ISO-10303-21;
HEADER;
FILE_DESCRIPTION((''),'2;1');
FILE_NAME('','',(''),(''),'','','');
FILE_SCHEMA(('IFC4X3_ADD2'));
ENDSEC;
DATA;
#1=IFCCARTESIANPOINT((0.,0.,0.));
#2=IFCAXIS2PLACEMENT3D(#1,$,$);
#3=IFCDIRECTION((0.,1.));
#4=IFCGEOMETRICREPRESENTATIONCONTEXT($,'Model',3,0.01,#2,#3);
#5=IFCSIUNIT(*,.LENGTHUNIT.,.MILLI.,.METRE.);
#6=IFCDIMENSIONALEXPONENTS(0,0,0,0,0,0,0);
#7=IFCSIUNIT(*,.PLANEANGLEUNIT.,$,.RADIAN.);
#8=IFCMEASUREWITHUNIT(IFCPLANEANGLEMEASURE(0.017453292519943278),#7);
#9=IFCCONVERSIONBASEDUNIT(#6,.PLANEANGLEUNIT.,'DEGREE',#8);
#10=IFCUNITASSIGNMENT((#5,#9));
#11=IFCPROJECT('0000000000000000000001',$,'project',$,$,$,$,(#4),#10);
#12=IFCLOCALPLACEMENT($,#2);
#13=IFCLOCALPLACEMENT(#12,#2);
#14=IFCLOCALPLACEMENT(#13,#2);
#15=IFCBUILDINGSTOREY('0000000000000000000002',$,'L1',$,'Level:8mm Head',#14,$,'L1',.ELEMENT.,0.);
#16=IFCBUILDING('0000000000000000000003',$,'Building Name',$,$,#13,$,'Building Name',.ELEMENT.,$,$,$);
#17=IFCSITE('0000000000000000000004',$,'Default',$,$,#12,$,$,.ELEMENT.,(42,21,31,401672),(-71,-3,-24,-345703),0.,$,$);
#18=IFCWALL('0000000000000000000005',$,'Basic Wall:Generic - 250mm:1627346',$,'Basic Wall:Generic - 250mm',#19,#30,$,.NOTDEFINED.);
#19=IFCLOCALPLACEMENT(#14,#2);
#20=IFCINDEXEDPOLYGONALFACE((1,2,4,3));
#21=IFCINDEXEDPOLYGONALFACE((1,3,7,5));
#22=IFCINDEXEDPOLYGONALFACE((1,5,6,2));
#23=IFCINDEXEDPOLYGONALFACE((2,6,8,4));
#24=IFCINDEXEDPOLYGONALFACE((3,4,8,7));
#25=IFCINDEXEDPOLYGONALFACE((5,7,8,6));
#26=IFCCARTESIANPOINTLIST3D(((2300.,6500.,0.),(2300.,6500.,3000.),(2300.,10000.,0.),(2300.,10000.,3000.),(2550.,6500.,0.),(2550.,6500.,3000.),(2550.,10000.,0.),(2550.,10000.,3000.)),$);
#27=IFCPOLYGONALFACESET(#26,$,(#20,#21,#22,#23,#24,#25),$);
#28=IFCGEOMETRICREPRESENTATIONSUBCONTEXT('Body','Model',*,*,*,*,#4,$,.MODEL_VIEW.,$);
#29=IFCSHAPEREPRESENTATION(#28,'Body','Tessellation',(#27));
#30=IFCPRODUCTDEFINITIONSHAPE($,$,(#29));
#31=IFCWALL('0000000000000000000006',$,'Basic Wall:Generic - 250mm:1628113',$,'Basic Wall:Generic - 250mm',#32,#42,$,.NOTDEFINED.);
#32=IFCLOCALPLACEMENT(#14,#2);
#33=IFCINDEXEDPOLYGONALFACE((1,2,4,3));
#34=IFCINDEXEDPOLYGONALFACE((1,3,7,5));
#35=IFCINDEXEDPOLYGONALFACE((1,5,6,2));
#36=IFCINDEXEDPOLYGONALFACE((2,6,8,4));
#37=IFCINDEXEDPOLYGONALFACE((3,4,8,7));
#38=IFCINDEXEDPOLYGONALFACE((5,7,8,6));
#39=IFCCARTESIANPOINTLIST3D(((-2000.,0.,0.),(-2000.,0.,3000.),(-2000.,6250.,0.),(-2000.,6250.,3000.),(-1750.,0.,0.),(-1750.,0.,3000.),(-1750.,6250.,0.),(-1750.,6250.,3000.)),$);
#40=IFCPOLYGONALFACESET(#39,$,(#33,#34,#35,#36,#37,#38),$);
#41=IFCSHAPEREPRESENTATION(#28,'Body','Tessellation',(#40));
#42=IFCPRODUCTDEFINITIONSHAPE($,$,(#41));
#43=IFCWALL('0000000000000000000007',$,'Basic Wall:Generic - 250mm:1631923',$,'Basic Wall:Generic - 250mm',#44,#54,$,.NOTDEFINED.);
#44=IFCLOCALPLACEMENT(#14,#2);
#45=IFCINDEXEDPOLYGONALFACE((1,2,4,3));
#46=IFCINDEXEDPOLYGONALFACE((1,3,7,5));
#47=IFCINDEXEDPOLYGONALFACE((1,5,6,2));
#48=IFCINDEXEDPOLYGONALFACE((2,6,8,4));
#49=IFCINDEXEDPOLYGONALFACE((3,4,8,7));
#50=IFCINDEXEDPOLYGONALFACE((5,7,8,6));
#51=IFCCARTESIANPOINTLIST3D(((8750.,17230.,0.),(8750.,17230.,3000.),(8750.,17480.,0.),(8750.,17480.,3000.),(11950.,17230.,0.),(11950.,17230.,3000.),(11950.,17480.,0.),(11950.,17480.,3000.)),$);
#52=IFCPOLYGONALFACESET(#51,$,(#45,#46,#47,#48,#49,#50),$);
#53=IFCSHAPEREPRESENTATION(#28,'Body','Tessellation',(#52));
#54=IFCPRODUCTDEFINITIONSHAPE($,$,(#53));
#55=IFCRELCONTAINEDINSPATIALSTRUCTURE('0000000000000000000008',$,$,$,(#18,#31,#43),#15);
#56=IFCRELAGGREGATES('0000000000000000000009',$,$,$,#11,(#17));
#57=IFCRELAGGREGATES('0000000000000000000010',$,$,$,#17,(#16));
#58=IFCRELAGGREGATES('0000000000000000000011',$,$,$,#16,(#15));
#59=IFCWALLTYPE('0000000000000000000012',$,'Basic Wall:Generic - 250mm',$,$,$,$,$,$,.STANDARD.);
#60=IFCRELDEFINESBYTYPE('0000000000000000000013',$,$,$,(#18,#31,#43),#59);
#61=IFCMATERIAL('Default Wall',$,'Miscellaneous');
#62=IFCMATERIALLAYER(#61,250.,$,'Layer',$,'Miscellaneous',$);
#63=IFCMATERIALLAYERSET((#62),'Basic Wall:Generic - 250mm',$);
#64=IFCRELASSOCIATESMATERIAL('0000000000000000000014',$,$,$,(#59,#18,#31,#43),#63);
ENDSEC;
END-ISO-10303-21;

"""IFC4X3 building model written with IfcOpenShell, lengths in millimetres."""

from ifc_helpers import new_model, entity, si_unit, converted_unit, direction, frame, frame_2d, origin, place, context, subcontext, project, spatial, rectangle, extrude, material, layer, layer_set, type_object, element, save


model = new_model("IFC4X3")

# Units and contexts
model_context = context("Model", 3, precision=0.01, world=origin(), true_north=direction((0.0, 1.0)))
body_context = subcontext(model_context, "Body", "Model", "MODEL_VIEW")
ifc_project = project(units=[si_unit("LENGTHUNIT", "METRE", prefix="MILLI"), converted_unit("PLANEANGLEUNIT", "DEGREE", entity("IfcPlaneAngleMeasure", 0.017453292519943278), si_unit("PLANEANGLEUNIT", "RADIAN"), dimensions=[0, 0, 0, 0, 0, 0, 0])], contexts=[model_context])

# Site, building, storey
site_placement = place(None, origin())
site = spatial("IfcSite", under=ifc_project, at=site_placement, Name="Default", CompositionType="ELEMENT", RefLatitude=(42, 21, 31, 401672), RefLongitude=(-71, -3, -24, -345703), RefElevation=0.0)
building_placement = place(site_placement, origin())
building = spatial("IfcBuilding", under=site, at=building_placement, Name="Building Name", LongName="Building Name", CompositionType="ELEMENT")
storey_placement = place(building_placement, origin())
storey = spatial("IfcBuildingStorey", under=building, at=storey_placement, Name="L1", ObjectType="Level:8mm Head", LongName="L1", CompositionType="ELEMENT", Elevation=0.0)

# Shared definitions
ifc_material = material(Name="Default Wall", Category="Miscellaneous")
ifc_layer = layer(ifc_material, 250.0, Name="Layer", Category="Miscellaneous")
ifc_layer_set = layer_set([ifc_layer], Name="Basic Wall:Generic - 250mm")
wall_type = type_object("IfcWallType", Name="Basic Wall:Generic - 250mm", PredefinedType="STANDARD", material=ifc_layer_set)

# Walls
wall_1_placement = place(storey_placement, frame((2425.0, 6500.0, 0.0), z_axis=(0.0, 0.0, 1.0), x_axis=(0.0, 1.0, 0.0)))
element("IfcWall", 1, at=wall_1_placement, inside=storey, type_object=wall_type, material=ifc_layer_set, Name="Basic Wall:Generic - 250mm:1627346", ObjectType="Basic Wall:Generic - 250mm", PredefinedType="NOTDEFINED", context=body_context, shape_type="SweptSolid", body=[
    extrude(rectangle(XDim=3500.0, YDim=250.0, at=frame_2d((1750.0, 0.0), x_axis=(-1.0, 0.0))), origin(), (0.0, 0.0, 1.0), 3000.0),
])
wall_2_placement = place(storey_placement, frame((-1875.0, 6250.0, 0.0), z_axis=(0.0, 0.0, 1.0), x_axis=(0.0, -1.0, 0.0)))
element("IfcWall", 2, at=wall_2_placement, inside=storey, type_object=wall_type, material=ifc_layer_set, Name="Basic Wall:Generic - 250mm:1628113", ObjectType="Basic Wall:Generic - 250mm", PredefinedType="NOTDEFINED", context=body_context, shape_type="SweptSolid", body=[
    extrude(rectangle(XDim=6250.0, YDim=250.0, at=frame_2d((3125.0, 0.0), x_axis=(-1.0, 0.0))), origin(), (0.0, 0.0, 1.0), 3000.0),
])
wall_3_placement = place(storey_placement, frame((11950.0, 17355.0, 0.0), z_axis=(0.0, 0.0, 1.0), x_axis=(-1.0, 0.0, 0.0)))
element("IfcWall", 3, at=wall_3_placement, inside=storey, type_object=wall_type, material=ifc_layer_set, Name="Basic Wall:Generic - 250mm:1631923", ObjectType="Basic Wall:Generic - 250mm", PredefinedType="NOTDEFINED", context=body_context, shape_type="SweptSolid", body=[
    extrude(rectangle(XDim=3200.0, YDim=250.0, at=frame_2d((1600.0, 0.0), x_axis=(-1.0, 0.0))), origin(), (0.0, 0.0, 1.0), 3000.0),
])

save(model, "model.ifc")
